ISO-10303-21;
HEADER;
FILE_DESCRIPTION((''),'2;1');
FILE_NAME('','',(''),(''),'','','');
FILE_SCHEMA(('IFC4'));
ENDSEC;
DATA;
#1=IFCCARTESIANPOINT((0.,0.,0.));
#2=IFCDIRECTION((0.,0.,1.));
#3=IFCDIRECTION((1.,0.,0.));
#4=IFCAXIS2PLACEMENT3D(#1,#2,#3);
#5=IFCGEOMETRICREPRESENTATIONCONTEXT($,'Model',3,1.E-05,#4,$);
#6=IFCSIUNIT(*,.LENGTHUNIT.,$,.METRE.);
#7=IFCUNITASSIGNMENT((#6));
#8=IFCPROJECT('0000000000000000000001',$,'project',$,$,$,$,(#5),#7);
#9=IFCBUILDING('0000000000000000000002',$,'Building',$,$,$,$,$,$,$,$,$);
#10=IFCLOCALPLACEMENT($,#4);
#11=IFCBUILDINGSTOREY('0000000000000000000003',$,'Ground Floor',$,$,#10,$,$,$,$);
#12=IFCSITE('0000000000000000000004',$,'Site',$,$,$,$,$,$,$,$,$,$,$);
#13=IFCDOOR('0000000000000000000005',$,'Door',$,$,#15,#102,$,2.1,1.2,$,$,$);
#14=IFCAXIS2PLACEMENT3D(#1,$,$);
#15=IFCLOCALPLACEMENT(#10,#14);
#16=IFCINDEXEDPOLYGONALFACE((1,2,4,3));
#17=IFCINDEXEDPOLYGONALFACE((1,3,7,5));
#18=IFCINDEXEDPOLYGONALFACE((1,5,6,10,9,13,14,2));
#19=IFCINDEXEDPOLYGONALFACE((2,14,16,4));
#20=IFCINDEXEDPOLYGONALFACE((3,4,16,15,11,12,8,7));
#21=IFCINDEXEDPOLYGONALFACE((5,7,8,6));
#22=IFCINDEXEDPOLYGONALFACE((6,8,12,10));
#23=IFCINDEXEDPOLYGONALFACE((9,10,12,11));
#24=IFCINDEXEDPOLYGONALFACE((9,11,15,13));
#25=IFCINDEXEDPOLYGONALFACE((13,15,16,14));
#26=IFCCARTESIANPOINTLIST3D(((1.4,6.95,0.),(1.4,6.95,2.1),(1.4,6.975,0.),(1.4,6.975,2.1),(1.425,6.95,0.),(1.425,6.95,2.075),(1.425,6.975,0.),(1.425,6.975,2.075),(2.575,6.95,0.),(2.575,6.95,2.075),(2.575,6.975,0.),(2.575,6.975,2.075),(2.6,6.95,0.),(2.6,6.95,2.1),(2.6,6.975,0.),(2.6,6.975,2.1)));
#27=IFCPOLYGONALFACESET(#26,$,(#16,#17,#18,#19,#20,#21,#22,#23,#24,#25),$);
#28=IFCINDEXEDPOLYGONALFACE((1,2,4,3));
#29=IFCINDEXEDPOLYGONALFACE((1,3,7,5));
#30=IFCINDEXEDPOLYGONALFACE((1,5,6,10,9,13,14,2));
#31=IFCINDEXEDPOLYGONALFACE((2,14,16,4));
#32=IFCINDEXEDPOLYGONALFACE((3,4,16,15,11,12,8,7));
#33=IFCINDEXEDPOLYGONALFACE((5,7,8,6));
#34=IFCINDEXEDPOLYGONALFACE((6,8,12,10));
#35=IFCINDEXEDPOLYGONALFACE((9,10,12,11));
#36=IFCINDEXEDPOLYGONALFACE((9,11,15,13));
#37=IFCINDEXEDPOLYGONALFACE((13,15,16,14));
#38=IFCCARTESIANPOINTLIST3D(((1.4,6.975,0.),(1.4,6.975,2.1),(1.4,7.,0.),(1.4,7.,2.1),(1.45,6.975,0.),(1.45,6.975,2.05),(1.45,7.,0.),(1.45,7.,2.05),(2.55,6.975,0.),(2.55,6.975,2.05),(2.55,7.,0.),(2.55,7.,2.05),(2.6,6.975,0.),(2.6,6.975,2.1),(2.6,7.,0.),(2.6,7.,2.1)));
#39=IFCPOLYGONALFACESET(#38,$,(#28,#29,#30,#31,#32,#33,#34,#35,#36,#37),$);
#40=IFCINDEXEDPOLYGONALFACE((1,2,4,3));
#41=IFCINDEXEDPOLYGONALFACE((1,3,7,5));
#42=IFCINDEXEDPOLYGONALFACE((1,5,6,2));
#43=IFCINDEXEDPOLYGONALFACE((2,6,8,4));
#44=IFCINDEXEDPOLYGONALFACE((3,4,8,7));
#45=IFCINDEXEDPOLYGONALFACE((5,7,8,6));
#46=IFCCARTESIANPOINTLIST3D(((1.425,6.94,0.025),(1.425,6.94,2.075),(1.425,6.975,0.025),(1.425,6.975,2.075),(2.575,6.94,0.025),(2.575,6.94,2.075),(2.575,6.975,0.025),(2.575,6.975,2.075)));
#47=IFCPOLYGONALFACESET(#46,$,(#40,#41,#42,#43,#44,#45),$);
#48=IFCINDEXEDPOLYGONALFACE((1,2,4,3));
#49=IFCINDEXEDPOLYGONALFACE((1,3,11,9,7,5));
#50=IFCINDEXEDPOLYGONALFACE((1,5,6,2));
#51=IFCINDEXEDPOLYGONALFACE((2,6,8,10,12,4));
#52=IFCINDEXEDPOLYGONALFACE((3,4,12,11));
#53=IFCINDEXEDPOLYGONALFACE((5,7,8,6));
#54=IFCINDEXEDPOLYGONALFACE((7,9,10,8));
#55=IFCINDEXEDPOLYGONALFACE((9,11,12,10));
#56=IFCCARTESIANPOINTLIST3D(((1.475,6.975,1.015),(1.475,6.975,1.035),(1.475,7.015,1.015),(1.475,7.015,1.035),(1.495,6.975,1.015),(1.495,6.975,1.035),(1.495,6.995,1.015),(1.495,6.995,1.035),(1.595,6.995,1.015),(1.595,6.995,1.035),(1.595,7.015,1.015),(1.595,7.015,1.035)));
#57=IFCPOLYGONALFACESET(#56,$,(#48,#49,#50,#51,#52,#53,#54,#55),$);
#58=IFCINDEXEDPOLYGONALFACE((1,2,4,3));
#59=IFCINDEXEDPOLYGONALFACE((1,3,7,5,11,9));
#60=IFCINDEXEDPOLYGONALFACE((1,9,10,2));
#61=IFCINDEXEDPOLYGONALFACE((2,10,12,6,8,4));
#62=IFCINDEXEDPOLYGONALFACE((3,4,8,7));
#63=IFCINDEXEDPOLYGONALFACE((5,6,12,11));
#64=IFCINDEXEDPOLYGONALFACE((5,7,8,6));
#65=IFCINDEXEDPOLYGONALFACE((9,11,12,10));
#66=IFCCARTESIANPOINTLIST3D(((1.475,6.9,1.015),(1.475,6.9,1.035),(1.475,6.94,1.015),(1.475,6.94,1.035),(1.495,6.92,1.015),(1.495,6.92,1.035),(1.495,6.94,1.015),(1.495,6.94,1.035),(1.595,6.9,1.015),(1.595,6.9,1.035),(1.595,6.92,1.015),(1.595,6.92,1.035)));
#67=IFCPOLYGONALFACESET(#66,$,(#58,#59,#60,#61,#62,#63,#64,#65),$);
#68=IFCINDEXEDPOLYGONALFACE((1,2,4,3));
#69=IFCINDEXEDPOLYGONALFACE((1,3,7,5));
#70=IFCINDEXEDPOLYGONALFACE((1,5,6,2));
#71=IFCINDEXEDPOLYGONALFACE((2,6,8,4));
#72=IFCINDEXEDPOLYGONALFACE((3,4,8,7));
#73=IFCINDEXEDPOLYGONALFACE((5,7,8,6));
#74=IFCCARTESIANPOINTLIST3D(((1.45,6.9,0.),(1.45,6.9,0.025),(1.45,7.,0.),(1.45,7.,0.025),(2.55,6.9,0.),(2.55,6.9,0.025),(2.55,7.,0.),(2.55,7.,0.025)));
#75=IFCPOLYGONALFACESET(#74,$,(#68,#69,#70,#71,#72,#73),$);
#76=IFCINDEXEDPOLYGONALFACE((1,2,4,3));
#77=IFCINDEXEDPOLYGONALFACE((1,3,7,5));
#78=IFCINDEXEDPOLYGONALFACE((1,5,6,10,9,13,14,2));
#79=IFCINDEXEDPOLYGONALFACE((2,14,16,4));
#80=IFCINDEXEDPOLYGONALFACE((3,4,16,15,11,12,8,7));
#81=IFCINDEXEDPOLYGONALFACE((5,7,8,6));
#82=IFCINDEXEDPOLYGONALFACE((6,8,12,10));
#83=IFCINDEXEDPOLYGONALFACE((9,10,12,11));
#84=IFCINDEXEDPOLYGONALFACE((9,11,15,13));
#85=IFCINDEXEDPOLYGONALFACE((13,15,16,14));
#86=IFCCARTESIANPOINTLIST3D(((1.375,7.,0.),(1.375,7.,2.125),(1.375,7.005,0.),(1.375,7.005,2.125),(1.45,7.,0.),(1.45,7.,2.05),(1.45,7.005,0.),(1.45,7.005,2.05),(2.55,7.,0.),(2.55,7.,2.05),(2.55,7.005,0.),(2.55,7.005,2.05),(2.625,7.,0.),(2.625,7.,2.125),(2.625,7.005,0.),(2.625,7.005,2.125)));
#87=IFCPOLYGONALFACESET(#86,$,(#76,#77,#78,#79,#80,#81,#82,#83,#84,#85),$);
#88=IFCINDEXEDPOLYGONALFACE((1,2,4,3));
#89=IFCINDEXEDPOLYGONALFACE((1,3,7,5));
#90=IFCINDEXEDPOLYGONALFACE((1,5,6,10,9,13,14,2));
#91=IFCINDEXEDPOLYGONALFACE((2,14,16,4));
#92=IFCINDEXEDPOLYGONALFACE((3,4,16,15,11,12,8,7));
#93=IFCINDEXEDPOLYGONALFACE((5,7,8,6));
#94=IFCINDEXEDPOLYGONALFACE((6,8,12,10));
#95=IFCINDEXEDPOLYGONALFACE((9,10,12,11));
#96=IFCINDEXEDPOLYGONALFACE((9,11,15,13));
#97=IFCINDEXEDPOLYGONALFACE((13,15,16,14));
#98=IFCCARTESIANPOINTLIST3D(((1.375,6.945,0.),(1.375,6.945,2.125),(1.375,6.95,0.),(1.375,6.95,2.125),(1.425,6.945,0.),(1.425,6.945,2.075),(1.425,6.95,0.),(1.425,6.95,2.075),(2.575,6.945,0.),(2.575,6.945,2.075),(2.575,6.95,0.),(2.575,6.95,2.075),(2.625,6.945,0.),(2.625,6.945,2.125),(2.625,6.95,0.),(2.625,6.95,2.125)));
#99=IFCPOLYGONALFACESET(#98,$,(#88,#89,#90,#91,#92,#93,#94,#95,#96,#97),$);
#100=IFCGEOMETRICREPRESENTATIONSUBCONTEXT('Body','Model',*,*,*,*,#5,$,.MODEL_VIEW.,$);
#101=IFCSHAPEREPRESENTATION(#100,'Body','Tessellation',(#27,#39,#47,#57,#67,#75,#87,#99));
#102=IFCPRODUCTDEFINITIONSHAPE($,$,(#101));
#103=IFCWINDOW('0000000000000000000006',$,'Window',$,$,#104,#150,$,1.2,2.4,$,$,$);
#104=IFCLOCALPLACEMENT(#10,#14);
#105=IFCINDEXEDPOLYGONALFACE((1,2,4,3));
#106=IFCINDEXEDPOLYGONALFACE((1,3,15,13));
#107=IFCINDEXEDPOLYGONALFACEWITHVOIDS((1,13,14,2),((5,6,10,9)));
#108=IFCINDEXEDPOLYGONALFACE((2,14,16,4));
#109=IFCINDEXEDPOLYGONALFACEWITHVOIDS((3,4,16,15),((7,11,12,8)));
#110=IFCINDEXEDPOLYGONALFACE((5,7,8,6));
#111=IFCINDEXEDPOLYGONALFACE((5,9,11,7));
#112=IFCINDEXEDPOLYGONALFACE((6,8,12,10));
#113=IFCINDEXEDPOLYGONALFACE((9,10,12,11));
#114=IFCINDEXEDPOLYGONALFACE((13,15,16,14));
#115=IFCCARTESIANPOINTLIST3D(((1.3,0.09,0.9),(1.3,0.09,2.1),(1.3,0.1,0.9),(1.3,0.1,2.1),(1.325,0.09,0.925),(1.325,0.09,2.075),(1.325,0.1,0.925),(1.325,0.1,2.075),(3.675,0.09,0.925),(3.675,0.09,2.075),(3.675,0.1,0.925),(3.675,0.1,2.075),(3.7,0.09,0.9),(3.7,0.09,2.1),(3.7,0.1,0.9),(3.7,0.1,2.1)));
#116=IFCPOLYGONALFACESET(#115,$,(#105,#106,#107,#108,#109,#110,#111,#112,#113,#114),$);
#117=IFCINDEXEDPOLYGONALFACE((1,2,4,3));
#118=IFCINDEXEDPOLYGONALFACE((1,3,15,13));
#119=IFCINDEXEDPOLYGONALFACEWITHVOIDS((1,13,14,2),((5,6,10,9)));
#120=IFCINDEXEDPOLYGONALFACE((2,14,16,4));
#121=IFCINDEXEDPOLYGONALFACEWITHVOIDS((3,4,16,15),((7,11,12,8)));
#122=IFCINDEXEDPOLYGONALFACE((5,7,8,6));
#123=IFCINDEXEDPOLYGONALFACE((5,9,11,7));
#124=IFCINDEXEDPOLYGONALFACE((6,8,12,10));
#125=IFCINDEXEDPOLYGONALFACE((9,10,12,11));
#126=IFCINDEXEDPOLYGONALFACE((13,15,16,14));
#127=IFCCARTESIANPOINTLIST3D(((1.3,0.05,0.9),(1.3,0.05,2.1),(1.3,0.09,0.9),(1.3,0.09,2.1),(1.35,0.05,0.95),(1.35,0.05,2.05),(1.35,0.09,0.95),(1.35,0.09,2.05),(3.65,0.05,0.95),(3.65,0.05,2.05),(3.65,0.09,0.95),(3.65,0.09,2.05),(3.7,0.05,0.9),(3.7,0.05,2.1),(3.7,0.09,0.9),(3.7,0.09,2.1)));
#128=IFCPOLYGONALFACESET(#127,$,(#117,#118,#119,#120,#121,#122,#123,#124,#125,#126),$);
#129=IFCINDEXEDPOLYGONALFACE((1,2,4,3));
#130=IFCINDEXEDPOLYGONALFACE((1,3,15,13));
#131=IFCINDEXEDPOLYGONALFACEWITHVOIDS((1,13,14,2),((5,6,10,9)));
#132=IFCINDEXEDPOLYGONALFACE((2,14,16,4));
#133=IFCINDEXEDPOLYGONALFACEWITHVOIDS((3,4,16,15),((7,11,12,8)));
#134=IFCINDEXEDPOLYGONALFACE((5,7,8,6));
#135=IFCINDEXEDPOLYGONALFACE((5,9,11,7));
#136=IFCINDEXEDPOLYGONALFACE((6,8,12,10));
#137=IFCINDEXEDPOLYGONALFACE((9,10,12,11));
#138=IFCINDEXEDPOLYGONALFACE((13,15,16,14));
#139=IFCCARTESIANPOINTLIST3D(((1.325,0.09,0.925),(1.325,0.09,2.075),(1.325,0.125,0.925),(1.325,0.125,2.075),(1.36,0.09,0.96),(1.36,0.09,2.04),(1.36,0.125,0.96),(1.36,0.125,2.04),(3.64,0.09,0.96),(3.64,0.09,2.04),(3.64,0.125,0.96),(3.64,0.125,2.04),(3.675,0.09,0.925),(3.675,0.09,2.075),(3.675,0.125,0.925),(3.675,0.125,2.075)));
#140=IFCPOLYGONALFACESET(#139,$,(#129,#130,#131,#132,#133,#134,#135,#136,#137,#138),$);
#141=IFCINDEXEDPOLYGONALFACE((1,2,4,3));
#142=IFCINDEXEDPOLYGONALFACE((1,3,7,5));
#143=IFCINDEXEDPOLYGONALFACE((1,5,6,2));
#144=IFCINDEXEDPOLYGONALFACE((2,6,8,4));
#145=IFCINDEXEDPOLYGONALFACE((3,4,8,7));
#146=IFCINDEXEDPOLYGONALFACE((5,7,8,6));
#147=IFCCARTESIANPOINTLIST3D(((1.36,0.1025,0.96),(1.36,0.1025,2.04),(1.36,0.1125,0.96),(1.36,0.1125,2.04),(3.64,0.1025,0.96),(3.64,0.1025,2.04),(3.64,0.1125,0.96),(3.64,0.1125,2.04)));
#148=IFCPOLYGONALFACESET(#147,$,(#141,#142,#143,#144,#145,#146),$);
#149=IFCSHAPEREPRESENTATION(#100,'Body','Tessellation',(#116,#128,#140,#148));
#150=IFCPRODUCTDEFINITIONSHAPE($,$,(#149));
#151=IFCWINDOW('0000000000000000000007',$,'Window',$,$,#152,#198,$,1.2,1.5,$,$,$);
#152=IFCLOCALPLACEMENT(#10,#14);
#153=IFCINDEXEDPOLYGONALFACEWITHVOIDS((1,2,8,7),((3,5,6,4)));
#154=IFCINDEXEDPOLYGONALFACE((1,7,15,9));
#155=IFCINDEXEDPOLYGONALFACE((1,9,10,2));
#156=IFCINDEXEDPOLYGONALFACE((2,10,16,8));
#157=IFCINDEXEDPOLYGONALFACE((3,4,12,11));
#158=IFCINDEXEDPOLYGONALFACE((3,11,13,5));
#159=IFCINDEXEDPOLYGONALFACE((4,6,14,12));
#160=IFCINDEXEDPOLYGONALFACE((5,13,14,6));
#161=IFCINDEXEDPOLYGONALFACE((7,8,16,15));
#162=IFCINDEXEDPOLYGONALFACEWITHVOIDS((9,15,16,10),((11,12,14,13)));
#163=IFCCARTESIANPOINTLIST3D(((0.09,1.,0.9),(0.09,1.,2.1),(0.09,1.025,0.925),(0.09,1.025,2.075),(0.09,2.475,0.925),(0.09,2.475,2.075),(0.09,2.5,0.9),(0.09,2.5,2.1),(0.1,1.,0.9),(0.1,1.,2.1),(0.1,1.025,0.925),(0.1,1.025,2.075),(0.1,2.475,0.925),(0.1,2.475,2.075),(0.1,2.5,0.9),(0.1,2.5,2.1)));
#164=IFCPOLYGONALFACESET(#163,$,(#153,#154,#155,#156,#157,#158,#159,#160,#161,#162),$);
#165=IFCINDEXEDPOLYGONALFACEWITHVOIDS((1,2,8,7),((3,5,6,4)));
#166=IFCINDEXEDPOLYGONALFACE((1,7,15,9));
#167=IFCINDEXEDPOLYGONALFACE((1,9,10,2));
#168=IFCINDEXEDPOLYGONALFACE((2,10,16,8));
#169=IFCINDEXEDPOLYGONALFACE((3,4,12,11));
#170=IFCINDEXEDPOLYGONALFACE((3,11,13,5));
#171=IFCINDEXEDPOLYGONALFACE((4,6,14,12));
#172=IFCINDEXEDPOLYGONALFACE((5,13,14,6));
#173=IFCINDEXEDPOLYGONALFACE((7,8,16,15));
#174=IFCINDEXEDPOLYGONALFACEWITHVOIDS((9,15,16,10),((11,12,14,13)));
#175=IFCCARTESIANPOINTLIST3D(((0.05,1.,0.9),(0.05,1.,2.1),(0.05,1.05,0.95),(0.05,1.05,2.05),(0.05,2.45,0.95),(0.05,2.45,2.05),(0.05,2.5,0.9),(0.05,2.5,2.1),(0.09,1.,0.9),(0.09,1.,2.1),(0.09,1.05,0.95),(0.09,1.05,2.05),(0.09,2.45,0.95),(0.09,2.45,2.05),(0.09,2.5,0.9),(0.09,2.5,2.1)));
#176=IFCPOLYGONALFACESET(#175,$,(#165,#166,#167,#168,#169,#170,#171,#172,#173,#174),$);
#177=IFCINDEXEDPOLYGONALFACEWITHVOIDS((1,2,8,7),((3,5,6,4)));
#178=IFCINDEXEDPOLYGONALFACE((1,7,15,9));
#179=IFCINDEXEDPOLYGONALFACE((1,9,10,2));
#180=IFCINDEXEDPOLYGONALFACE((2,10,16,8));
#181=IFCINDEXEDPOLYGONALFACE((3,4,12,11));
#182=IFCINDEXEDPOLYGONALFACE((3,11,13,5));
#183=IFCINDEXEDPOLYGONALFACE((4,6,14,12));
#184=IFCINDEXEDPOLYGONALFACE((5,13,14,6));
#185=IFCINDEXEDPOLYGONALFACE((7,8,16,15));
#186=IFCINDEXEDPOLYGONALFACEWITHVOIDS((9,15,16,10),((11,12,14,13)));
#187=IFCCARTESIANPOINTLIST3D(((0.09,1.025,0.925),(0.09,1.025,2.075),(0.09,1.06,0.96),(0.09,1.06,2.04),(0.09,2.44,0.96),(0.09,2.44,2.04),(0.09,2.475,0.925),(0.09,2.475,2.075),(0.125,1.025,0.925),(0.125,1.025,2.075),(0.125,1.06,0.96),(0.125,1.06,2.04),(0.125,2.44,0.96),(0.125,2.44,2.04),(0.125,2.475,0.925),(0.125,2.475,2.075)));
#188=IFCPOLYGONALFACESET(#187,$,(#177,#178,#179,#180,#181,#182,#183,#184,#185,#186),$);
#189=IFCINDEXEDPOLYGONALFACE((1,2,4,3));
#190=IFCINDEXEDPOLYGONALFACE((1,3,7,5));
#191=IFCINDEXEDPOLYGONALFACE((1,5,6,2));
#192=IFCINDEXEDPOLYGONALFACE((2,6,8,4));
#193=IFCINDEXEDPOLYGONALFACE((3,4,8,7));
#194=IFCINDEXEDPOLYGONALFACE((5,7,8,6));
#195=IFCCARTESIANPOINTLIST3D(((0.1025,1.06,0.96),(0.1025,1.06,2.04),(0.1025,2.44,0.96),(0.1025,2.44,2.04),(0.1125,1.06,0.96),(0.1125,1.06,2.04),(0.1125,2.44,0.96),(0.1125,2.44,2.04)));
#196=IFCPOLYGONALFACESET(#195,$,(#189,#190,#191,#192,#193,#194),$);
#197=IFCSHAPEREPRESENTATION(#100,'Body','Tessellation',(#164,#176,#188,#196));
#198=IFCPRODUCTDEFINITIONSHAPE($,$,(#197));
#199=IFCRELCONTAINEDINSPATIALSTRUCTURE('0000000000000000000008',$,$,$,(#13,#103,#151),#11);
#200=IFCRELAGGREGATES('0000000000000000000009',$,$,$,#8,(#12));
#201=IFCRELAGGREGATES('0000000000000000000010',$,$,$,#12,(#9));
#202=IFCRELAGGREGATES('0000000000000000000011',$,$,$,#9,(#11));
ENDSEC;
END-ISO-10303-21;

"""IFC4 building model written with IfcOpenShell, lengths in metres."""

from ifc_helpers import new_model, si_unit, frame, origin_with_axes, place, context, subcontext, project, spatial, line, indexed_curve, outline, extrude, element, save


model = new_model("IFC4")

# Units and contexts
model_context = context("Model", 3, precision=1e-05, world=origin_with_axes())
body_context = subcontext(model_context, "Body", "Model", "MODEL_VIEW")
ifc_project = project(units=[si_unit("LENGTHUNIT", "METRE")], contexts=[model_context])

# Site, building, storey
site = spatial("IfcSite", under=ifc_project, Name="Site")
building = spatial("IfcBuilding", under=site, Name="Building")
storey_placement = place(None, origin_with_axes())
storey = spatial("IfcBuildingStorey", under=building, at=storey_placement, Name="Ground Floor")

# Door
door_1_placement = place(storey_placement, frame((2.6, 7.0, 0.0), z_axis=(0.0, 0.0, 1.0), x_axis=(-1.0, 0.0, 0.0)))
element("IfcDoor", 1, at=door_1_placement, inside=storey, Name="Door", OverallHeight=2.1, OverallWidth=1.2, context=body_context, shape_type="SweptSolid", body=[
    extrude(outline(indexed_curve([(0.0, 0.0), (0.0, 2.1), (1.2, 2.1), (1.2, 0.0), (1.175, 0.0), (1.175, 2.075), (0.025, 2.075), (0.025, 0.0)], segments=[line(1, 2, 3, 4, 5, 6, 7, 8, 1)])), frame((0.0, 0.025, 0.0), z_axis=(0.0, -1.0, 0.0), x_axis=(1.0, 0.0, 0.0)), (0.0, 0.0, -1.0), 0.025),
    extrude(outline(indexed_curve([(0.0, 0.0), (0.0, 2.1), (1.2, 2.1), (1.2, 0.0), (1.15, 0.0), (1.15, 2.05), (0.05, 2.05), (0.05, 0.0)], segments=[line(1, 2, 3, 4, 5, 6, 7, 8, 1)])), frame((0.0, 0.0, 0.0), z_axis=(0.0, -1.0, 0.0), x_axis=(1.0, 0.0, 0.0)), (0.0, 0.0, -1.0), 0.025),
    extrude(outline(indexed_curve([(0.0, 0.0), (1.15, 0.0), (1.15, 0.035), (0.0, 0.035)], segments=[line(1, 2, 3, 4, 1)])), frame((0.025, 0.025, 0.025), z_axis=(0.0, 0.0, 1.0), x_axis=(1.0, 0.0, 0.0)), (0.0, 0.0, 1.0), 2.05),
    extrude(outline(indexed_curve([(0.0, 0.0), (0.0, -0.04), (-0.12, -0.04), (-0.12, -0.02), (-0.02, -0.02), (-0.02, 0.0)], segments=[line(1, 2, 3, 4, 5, 6, 1)])), frame((1.125, 0.025, 1.015), z_axis=(0.0, 0.0, 1.0), x_axis=(1.0, 0.0, 0.0)), (0.0, 0.0, 1.0), 0.02),
    extrude(outline(indexed_curve([(0.0, 0.0), (0.0, 0.04), (-0.12, 0.04), (-0.12, 0.02), (-0.02, 0.02), (-0.02, 0.0)], segments=[line(1, 2, 3, 4, 5, 6, 1)])), frame((1.125, 0.06, 1.015), z_axis=(0.0, 0.0, 1.0), x_axis=(1.0, 0.0, 0.0)), (0.0, 0.0, 1.0), 0.02),
    extrude(outline(indexed_curve([(0.0, 0.0), (1.1, 0.0), (1.1, 0.1), (0.0, 0.1)], segments=[line(1, 2, 3, 4, 1)])), frame((0.05, 0.0, 0.0), z_axis=(0.0, 0.0, 1.0), x_axis=(1.0, 0.0, 0.0)), (0.0, 0.0, 1.0), 0.025),
    extrude(outline(indexed_curve([(0.0, 0.0), (0.0, 2.125), (1.25, 2.125), (1.25, 0.0), (1.175, 0.0), (1.175, 2.05), (0.075, 2.05), (0.075, 0.0)], segments=[line(1, 2, 3, 4, 5, 6, 7, 8, 1)])), frame((-0.025, -0.005, 0.0), z_axis=(0.0, -1.0, 0.0), x_axis=(1.0, 0.0, 0.0)), (0.0, 0.0, -1.0), 0.005),
    extrude(outline(indexed_curve([(0.0, 0.0), (0.0, 2.125), (1.25, 2.125), (1.25, 0.0), (1.2, 0.0), (1.2, 2.075), (0.05, 2.075), (0.05, 0.0)], segments=[line(1, 2, 3, 4, 5, 6, 7, 8, 1)])), frame((-0.025, 0.05, 0.0), z_axis=(0.0, -1.0, 0.0), x_axis=(1.0, 0.0, 0.0)), (0.0, 0.0, -1.0), 0.005),
])

# Windows
window_1_placement = place(storey_placement, frame((1.3, 0.0, 0.9), z_axis=(0.0, 0.0, 1.0), x_axis=(1.0, 0.0, 0.0)))
element("IfcWindow", 2, at=window_1_placement, inside=storey, Name="Window", OverallHeight=1.2, OverallWidth=2.4, context=body_context, shape_type="SweptSolid", body=[
    extrude(outline(indexed_curve([(0.0, 0.0), (2.4, 0.0), (2.4, 1.2), (0.0, 1.2)], segments=[line(1, 2, 3, 4, 1)]), holes=[indexed_curve([(0.025, 0.025), (2.375, 0.025), (2.375, 1.175), (0.025, 1.175)], segments=[line(1, 2, 3, 4, 1)])]), frame((0.0, 0.09, 0.0), z_axis=(0.0, -1.0, 0.0), x_axis=(1.0, 0.0, 0.0)), (0.0, 0.0, -1.0), 0.01),
    extrude(outline(indexed_curve([(0.0, 0.0), (2.4, 0.0), (2.4, 1.2), (0.0, 1.2)], segments=[line(1, 2, 3, 4, 1)]), holes=[indexed_curve([(0.05, 0.05), (2.35, 0.05), (2.35, 1.15), (0.05, 1.15)], segments=[line(1, 2, 3, 4, 1)])]), frame((0.0, 0.05, 0.0), z_axis=(0.0, -1.0, 0.0), x_axis=(1.0, 0.0, 0.0)), (0.0, 0.0, -1.0), 0.04),
    extrude(outline(indexed_curve([(0.0, 0.0), (2.35, 0.0), (2.35, 1.15), (0.0, 1.15)], segments=[line(1, 2, 3, 4, 1)]), holes=[indexed_curve([(0.035, 0.035), (2.315, 0.035), (2.315, 1.115), (0.035, 1.115)], segments=[line(1, 2, 3, 4, 1)])]), frame((0.025, 0.09, 0.025), z_axis=(0.0, -1.0, 0.0), x_axis=(1.0, 0.0, 0.0)), (0.0, 0.0, -1.0), 0.035),
    extrude(outline(indexed_curve([(0.035, 0.035), (2.315, 0.035), (2.315, 1.115), (0.035, 1.115)], segments=[line(1, 2, 3, 4, 1)])), frame((0.025, 0.1025, 0.025), z_axis=(0.0, -1.0, 0.0), x_axis=(1.0, 0.0, 0.0)), (0.0, 0.0, -1.0), 0.01),
])
window_2_placement = place(storey_placement, frame((0.0, 2.5, 0.9), z_axis=(0.0, 0.0, 1.0), x_axis=(0.0, -1.0, 0.0)))
element("IfcWindow", 3, at=window_2_placement, inside=storey, Name="Window", OverallHeight=1.2, OverallWidth=1.5, context=body_context, shape_type="SweptSolid", body=[
    extrude(outline(indexed_curve([(0.0, 0.0), (1.5, 0.0), (1.5, 1.2), (0.0, 1.2)], segments=[line(1, 2, 3, 4, 1)]), holes=[indexed_curve([(0.025, 0.025), (1.475, 0.025), (1.475, 1.175), (0.025, 1.175)], segments=[line(1, 2, 3, 4, 1)])]), frame((0.0, 0.09, 0.0), z_axis=(0.0, -1.0, 0.0), x_axis=(1.0, 0.0, 0.0)), (0.0, 0.0, -1.0), 0.01),
    extrude(outline(indexed_curve([(0.0, 0.0), (1.5, 0.0), (1.5, 1.2), (0.0, 1.2)], segments=[line(1, 2, 3, 4, 1)]), holes=[indexed_curve([(0.05, 0.05), (1.45, 0.05), (1.45, 1.15), (0.05, 1.15)], segments=[line(1, 2, 3, 4, 1)])]), frame((0.0, 0.05, 0.0), z_axis=(0.0, -1.0, 0.0), x_axis=(1.0, 0.0, 0.0)), (0.0, 0.0, -1.0), 0.04),
    extrude(outline(indexed_curve([(0.0, 0.0), (1.45, 0.0), (1.45, 1.15), (0.0, 1.15)], segments=[line(1, 2, 3, 4, 1)]), holes=[indexed_curve([(0.035, 0.035), (1.415, 0.035), (1.415, 1.115), (0.035, 1.115)], segments=[line(1, 2, 3, 4, 1)])]), frame((0.025, 0.09, 0.025), z_axis=(0.0, -1.0, 0.0), x_axis=(1.0, 0.0, 0.0)), (0.0, 0.0, -1.0), 0.035),
    extrude(outline(indexed_curve([(0.035, 0.035), (1.415, 0.035), (1.415, 1.115), (0.035, 1.115)], segments=[line(1, 2, 3, 4, 1)])), frame((0.025, 0.1025, 0.025), z_axis=(0.0, -1.0, 0.0), x_axis=(1.0, 0.0, 0.0)), (0.0, 0.0, -1.0), 0.01),
])

save(model, "model.ifc")
